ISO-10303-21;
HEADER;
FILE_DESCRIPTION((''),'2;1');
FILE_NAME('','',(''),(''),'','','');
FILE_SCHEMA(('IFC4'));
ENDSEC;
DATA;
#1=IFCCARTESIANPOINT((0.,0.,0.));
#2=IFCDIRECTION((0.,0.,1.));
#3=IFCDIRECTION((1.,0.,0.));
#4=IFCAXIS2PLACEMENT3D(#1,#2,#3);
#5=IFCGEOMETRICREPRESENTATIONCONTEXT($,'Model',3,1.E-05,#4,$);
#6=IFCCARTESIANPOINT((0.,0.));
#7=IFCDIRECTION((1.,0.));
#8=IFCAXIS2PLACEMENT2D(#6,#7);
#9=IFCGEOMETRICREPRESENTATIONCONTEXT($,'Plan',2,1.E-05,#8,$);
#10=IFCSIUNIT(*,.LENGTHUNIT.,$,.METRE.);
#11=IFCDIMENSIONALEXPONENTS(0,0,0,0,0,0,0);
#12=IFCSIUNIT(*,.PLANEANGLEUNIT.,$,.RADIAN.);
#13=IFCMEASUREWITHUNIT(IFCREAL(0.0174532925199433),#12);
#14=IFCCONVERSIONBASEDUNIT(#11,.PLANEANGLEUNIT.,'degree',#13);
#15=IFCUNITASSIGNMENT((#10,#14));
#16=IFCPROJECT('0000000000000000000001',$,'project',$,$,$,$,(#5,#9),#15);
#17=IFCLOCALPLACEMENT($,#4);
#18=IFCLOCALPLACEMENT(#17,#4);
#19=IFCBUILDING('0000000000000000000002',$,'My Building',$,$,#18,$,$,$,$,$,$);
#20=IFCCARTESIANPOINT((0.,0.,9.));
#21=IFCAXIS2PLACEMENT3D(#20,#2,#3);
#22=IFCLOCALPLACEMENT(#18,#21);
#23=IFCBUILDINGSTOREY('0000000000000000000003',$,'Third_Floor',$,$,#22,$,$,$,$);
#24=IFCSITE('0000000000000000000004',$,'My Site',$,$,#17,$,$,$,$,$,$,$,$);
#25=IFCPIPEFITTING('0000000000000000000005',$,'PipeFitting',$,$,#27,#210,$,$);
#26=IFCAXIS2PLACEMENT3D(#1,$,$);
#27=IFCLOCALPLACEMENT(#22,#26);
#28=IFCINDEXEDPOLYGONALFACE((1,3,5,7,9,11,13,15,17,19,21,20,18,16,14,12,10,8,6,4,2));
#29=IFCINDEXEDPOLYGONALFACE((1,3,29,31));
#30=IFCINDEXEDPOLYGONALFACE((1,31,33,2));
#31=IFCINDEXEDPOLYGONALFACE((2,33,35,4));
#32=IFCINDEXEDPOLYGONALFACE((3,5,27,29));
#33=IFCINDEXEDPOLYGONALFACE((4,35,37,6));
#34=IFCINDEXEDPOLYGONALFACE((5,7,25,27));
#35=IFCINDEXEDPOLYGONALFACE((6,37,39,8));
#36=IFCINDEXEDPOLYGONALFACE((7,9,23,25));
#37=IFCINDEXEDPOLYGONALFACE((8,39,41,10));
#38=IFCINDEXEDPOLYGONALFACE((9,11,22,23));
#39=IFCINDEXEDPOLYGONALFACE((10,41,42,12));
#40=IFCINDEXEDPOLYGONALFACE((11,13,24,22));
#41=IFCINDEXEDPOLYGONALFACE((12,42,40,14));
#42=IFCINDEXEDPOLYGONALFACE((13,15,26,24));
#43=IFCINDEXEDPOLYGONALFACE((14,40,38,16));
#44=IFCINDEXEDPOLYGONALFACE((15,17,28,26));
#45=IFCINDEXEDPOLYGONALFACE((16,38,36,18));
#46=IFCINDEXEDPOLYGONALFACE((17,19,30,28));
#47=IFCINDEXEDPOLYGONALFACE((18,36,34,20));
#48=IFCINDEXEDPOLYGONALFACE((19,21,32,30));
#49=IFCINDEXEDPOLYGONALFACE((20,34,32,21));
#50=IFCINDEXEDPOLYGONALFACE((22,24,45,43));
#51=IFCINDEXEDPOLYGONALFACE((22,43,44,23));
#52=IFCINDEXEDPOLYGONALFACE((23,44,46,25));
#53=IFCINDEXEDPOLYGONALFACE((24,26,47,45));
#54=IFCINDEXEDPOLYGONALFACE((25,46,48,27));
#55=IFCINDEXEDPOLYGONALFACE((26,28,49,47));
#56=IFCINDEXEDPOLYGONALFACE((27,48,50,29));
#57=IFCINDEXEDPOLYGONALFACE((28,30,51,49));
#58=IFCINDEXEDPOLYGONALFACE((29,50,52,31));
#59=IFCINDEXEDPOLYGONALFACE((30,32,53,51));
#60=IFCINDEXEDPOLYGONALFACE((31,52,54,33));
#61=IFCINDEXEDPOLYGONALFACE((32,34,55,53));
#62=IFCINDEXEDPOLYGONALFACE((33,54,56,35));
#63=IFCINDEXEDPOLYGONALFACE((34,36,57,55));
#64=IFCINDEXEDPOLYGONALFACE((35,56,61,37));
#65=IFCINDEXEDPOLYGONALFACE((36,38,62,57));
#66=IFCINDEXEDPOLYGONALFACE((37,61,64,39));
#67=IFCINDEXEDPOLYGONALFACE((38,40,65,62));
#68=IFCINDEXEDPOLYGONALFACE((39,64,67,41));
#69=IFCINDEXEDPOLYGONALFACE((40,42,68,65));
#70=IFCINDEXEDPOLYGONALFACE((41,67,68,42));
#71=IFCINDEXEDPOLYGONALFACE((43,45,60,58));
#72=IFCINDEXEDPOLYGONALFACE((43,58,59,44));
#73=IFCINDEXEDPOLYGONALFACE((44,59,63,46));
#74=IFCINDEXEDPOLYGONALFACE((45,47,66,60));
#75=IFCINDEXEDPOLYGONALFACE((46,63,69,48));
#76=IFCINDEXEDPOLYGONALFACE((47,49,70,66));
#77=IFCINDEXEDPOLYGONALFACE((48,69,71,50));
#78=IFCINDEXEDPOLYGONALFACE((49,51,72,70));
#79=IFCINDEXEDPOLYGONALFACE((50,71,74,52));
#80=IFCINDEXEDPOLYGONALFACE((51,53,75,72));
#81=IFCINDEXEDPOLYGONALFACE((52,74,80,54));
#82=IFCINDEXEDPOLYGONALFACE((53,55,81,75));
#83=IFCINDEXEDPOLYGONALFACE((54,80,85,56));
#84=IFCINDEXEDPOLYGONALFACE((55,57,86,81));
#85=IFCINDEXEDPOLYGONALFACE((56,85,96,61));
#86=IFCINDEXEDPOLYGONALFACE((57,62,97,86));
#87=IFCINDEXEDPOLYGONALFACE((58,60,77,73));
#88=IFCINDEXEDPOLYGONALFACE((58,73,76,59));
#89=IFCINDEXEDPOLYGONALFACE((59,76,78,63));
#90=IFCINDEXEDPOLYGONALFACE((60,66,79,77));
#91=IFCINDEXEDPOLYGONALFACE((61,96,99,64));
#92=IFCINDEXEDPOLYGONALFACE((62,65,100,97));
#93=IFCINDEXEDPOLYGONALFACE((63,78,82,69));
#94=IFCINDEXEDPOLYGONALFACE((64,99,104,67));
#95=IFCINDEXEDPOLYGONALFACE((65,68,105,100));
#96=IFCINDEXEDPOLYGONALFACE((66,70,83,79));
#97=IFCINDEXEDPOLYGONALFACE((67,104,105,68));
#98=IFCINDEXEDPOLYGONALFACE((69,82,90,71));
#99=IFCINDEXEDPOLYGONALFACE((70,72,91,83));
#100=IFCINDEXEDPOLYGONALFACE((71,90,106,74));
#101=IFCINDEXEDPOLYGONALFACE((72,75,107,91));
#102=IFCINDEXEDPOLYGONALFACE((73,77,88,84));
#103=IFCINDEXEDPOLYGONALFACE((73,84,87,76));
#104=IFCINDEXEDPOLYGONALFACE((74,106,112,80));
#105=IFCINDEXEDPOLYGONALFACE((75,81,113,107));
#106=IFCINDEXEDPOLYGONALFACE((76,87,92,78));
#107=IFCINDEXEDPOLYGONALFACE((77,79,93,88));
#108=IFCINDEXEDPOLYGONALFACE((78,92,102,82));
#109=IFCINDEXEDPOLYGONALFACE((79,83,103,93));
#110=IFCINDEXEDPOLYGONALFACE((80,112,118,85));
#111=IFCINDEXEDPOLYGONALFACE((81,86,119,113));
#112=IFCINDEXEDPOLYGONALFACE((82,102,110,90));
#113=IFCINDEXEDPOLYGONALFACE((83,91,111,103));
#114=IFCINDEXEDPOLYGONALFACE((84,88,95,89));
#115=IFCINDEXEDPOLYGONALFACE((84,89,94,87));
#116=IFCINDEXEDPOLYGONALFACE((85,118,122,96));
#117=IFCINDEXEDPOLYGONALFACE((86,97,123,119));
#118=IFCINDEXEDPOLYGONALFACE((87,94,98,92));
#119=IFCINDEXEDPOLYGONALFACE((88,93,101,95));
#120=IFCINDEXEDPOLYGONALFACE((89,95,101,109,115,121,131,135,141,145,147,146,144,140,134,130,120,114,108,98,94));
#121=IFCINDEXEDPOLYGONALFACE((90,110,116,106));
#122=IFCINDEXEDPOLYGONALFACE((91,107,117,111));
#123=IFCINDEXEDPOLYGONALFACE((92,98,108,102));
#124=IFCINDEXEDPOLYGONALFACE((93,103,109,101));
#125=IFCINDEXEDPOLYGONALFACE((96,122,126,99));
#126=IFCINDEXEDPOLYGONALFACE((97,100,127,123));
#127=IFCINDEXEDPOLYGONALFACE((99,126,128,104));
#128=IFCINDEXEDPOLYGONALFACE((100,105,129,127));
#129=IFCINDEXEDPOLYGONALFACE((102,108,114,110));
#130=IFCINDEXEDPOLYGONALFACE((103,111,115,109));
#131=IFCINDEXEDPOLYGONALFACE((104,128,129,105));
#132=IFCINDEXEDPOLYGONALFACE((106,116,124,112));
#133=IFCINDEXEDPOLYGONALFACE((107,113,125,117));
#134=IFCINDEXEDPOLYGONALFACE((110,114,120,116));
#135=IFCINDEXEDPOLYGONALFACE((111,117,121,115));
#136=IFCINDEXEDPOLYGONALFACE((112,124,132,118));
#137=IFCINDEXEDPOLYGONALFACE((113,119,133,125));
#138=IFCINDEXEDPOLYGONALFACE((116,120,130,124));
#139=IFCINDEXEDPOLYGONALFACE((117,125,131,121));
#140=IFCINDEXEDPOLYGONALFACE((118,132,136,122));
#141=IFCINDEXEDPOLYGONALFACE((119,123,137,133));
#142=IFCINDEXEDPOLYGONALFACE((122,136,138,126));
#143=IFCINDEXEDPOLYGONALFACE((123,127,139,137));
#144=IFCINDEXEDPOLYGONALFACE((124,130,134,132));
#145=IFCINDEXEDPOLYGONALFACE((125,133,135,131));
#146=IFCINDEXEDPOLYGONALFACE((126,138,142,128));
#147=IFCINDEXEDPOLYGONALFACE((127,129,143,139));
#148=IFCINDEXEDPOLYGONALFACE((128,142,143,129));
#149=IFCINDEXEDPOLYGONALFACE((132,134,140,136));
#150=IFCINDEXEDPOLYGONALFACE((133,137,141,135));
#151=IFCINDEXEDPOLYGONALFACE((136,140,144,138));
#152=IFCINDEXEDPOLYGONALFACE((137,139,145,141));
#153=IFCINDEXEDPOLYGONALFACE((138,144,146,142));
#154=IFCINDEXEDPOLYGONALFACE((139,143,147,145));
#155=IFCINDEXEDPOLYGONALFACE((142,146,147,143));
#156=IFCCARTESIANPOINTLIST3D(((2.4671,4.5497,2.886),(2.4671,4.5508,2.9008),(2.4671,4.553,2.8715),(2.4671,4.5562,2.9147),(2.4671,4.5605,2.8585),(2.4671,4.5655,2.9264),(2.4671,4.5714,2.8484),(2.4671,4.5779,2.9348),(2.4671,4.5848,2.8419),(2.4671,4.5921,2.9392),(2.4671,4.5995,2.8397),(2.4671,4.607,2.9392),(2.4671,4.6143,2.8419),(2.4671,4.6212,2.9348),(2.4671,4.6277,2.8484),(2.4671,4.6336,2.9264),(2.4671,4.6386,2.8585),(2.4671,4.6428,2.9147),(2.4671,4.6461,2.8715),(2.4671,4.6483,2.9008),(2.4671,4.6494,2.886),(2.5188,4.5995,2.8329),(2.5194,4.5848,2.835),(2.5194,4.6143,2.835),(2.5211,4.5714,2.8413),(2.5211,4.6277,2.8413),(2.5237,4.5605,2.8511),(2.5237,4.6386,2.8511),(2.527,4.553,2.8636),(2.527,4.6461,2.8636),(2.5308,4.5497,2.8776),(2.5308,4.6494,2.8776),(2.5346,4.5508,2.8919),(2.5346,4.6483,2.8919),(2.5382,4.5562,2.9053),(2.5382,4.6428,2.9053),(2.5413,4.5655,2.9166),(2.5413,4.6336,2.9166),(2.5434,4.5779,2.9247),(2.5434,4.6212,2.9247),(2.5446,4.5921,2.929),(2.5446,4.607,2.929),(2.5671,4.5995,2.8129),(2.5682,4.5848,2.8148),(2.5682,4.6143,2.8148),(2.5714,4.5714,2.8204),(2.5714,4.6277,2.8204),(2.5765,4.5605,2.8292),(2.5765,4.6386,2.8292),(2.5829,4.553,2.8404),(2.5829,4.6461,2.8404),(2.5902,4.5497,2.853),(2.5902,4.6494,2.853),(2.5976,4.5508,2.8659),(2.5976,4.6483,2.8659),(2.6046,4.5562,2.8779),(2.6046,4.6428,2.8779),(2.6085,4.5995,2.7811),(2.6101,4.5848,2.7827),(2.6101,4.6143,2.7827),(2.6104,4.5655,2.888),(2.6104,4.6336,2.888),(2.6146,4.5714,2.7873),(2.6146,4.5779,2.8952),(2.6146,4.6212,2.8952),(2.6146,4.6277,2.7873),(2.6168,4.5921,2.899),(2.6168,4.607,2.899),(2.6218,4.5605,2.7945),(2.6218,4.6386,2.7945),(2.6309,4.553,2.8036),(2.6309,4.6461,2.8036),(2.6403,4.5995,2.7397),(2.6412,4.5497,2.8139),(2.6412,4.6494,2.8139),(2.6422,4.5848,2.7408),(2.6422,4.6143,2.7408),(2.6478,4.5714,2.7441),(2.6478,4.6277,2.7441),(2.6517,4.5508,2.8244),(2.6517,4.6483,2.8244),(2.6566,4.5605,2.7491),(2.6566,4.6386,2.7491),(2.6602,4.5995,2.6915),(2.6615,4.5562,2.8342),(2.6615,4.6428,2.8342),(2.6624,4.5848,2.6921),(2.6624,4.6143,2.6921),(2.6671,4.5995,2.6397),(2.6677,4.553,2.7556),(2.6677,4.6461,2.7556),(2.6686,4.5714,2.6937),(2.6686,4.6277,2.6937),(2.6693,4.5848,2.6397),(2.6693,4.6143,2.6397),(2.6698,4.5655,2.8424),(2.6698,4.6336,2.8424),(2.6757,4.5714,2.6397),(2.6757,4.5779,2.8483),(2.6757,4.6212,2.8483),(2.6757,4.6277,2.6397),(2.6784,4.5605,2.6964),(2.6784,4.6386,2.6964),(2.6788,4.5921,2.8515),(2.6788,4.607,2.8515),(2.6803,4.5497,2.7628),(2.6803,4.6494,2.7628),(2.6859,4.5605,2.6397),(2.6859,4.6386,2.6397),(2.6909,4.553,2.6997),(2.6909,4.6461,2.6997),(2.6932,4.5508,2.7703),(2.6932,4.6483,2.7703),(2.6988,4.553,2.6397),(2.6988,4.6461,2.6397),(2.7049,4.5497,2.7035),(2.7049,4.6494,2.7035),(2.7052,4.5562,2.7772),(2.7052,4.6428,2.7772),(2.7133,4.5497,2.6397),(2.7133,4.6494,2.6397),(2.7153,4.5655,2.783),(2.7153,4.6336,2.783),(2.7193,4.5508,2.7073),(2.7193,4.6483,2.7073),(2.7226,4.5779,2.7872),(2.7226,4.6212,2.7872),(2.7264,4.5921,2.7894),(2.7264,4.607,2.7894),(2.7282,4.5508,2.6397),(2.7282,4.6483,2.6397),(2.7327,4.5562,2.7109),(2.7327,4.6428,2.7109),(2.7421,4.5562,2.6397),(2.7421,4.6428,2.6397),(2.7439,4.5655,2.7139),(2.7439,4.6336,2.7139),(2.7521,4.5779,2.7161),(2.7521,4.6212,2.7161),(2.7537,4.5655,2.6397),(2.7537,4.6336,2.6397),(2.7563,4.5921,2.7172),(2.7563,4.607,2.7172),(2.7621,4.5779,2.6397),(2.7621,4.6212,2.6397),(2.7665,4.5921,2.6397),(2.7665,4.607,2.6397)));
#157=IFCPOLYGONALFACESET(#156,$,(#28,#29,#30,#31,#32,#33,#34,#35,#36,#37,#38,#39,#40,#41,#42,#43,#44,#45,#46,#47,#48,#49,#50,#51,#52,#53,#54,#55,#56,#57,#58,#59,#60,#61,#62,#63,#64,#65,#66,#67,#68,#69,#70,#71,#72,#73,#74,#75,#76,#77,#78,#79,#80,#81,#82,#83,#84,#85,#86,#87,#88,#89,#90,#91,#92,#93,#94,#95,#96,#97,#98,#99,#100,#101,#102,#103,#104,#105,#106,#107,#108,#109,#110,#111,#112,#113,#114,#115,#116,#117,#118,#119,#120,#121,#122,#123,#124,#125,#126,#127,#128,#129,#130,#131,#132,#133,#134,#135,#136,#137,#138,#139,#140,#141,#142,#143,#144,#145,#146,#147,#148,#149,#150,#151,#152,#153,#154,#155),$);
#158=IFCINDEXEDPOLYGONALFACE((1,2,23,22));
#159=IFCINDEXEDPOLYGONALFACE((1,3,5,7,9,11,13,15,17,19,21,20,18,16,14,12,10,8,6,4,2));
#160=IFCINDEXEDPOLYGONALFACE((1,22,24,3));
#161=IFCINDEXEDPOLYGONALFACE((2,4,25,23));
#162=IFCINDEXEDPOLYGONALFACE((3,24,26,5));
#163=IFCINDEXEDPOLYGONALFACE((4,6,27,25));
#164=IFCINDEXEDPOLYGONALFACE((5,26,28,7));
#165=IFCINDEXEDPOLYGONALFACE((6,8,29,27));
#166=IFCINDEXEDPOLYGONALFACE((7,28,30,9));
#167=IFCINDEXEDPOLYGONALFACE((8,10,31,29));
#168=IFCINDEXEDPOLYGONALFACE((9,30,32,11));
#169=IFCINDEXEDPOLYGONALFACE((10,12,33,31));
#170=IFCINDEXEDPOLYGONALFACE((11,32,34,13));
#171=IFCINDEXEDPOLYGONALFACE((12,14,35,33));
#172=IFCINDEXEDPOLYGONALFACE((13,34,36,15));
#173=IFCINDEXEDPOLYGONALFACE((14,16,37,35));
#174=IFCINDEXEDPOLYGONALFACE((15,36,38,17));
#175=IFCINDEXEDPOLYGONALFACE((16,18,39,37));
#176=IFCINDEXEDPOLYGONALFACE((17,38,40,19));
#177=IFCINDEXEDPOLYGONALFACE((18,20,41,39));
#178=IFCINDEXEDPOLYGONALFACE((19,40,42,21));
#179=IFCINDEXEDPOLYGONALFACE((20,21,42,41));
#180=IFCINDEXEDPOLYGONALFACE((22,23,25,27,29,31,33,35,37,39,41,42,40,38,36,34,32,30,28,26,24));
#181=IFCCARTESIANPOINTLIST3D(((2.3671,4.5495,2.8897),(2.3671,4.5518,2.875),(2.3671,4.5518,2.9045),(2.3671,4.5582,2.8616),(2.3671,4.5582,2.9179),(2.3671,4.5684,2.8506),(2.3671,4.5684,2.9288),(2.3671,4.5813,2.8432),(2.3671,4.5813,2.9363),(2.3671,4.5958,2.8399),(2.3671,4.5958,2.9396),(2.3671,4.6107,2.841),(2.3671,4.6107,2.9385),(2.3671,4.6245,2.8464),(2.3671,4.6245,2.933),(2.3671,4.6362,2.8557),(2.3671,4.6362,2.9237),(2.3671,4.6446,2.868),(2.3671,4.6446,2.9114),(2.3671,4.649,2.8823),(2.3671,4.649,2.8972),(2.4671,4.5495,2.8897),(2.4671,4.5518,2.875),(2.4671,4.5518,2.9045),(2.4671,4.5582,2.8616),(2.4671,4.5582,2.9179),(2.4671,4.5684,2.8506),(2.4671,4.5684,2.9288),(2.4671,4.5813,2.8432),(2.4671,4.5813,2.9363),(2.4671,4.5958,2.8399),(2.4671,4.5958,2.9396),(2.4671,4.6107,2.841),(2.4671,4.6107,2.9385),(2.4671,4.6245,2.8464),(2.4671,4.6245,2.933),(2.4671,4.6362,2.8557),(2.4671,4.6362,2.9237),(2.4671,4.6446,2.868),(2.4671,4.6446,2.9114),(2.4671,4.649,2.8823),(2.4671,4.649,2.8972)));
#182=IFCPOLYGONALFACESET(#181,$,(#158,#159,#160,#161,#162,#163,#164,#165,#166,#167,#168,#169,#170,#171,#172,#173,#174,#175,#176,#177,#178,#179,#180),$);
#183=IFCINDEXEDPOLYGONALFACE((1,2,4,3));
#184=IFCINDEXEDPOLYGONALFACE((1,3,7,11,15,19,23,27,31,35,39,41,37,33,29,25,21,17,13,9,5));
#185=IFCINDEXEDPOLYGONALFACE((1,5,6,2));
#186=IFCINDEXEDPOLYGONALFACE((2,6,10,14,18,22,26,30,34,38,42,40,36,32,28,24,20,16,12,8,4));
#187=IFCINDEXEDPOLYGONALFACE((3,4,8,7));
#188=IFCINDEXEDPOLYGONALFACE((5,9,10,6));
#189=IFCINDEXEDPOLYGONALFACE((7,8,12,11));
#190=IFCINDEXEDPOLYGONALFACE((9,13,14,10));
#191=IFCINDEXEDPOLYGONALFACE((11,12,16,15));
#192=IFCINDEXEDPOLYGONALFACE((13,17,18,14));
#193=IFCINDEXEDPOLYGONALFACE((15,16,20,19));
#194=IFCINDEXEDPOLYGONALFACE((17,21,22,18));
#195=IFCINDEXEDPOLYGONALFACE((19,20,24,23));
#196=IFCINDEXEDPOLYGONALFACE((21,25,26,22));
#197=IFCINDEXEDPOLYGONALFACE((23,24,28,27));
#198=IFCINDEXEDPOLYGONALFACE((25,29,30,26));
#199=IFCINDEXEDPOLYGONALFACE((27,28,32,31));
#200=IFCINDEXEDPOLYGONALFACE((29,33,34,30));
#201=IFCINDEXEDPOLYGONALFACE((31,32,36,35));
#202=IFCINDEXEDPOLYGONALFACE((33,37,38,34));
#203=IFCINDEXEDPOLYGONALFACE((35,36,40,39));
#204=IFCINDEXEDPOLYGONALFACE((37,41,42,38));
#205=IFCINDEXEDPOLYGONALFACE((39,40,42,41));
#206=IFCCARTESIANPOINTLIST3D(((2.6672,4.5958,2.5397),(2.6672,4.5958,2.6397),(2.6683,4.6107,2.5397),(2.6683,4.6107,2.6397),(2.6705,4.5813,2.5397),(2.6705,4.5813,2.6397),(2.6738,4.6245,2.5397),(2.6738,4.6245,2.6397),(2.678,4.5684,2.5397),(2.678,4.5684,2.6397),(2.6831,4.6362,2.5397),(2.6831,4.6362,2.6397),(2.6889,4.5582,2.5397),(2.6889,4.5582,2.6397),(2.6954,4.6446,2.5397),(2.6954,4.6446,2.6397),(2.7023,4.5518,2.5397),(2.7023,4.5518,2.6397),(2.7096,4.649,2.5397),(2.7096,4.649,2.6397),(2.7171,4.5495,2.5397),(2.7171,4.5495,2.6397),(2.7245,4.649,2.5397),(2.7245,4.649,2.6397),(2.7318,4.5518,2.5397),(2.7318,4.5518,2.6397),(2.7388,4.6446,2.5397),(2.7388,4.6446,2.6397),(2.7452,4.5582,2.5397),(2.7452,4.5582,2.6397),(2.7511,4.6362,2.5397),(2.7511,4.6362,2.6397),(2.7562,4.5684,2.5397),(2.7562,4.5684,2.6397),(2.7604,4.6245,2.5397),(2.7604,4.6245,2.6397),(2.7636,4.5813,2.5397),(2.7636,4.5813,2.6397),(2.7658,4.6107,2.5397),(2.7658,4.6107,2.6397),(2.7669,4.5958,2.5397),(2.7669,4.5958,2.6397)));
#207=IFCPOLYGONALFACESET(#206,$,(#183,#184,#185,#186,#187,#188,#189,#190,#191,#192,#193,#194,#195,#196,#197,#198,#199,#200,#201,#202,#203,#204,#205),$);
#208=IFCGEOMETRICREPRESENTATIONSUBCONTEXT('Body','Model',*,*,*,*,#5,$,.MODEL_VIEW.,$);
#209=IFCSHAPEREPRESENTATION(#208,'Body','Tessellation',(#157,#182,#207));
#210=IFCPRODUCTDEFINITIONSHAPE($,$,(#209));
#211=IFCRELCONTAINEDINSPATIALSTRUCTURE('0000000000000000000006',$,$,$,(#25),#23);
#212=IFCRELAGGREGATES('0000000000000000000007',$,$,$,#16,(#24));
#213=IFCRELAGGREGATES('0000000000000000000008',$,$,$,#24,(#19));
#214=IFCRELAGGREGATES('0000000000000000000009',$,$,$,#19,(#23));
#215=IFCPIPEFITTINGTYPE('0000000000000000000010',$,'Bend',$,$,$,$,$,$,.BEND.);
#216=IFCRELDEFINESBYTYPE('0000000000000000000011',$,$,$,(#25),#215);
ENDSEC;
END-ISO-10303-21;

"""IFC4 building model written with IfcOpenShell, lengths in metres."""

from ifc_helpers import new_model, entity, si_unit, converted_unit, frame, origin_with_axes, origin_2d_with_axis, place, context, subcontext, project, spatial, circle, extrude, source, transform, mapped, type_object, type_shapes, element, save


model = new_model("IFC4")

# Units and contexts
model_context = context("Model", 3, precision=1e-05, world=origin_with_axes())
plan_context = context("Plan", 2, precision=1e-05, world=origin_2d_with_axis())
body_context_1 = subcontext(model_context, "Body", "Model", "MODEL_VIEW")
ifc_project = project(units=[si_unit("LENGTHUNIT", "METRE"), converted_unit("PLANEANGLEUNIT", "degree", entity("IfcReal", 0.0174532925199433), si_unit("PLANEANGLEUNIT", "RADIAN"), dimensions=[0, 0, 0, 0, 0, 0, 0])], contexts=[model_context, plan_context])

# Site, building, storey
site_placement = place(None, origin_with_axes())
site = spatial("IfcSite", under=ifc_project, at=site_placement, Name="My Site")
building_placement = place(site_placement, origin_with_axes())
building = spatial("IfcBuilding", under=site, at=building_placement, Name="My Building")
storey_placement = place(building_placement, frame((0.0, 0.0, 9.0), z_axis=(0.0, 0.0, 1.0), x_axis=(1.0, 0.0, 0.0)))
storey = spatial("IfcBuildingStorey", under=building, at=storey_placement, Name="Third_Floor")

# Pipe fitting
pipe_fitting_type = type_object("IfcPipeFittingType", Name="Bend", PredefinedType="BEND")
shared_shape_1 = source(origin_with_axes(), body_context_1, "Body", "SolidModel", [
    entity("IfcSweptDiskSolid", entity("IfcIndexedPolyCurve", entity("IfcCartesianPointList3D", [[0.0, 0.0, -0.1], [0.0, -0.0732, -0.2768], [0.0, -0.25, -0.35]]), [entity("IfcArcIndex", [1, 2, 3])]), 0.05),
    extrude(circle(Radius=0.05), origin_with_axes(), (0.0, 0.0, -1.0), 0.1),
    extrude(circle(Radius=0.05), frame((0.0, -0.25, -0.35), z_axis=(0.0, -1.0, 0.0), x_axis=(1.0, 0.0, 0.0)), (0.0, 0.0, 1.0), 0.1),
])
type_shapes(pipe_fitting_type, [shared_shape_1])
for number, where, z_axis, x_axis, name in (
    (1, (2.3671, 4.5995, 2.8897), (-1.0, 0.0, 0.0), (0.0, -1.0, 0.0), "PipeFitting"),
):
    element("IfcPipeFitting", number, at=place(storey_placement, frame(where, z_axis=z_axis, x_axis=x_axis)), inside=storey, type_object=pipe_fitting_type, Name=name, context=body_context_1, shape_type="MappedRepresentation", body=[
        mapped(shared_shape_1, transform((0.0, 0.0, 0.0), x_axis=(1.0, 0.0, 0.0), y_axis=(0.0, 1.0, 0.0), z_axis=(0.0, 0.0, 1.0), scale=1.0)),
    ])

save(model, "model.ifc")
